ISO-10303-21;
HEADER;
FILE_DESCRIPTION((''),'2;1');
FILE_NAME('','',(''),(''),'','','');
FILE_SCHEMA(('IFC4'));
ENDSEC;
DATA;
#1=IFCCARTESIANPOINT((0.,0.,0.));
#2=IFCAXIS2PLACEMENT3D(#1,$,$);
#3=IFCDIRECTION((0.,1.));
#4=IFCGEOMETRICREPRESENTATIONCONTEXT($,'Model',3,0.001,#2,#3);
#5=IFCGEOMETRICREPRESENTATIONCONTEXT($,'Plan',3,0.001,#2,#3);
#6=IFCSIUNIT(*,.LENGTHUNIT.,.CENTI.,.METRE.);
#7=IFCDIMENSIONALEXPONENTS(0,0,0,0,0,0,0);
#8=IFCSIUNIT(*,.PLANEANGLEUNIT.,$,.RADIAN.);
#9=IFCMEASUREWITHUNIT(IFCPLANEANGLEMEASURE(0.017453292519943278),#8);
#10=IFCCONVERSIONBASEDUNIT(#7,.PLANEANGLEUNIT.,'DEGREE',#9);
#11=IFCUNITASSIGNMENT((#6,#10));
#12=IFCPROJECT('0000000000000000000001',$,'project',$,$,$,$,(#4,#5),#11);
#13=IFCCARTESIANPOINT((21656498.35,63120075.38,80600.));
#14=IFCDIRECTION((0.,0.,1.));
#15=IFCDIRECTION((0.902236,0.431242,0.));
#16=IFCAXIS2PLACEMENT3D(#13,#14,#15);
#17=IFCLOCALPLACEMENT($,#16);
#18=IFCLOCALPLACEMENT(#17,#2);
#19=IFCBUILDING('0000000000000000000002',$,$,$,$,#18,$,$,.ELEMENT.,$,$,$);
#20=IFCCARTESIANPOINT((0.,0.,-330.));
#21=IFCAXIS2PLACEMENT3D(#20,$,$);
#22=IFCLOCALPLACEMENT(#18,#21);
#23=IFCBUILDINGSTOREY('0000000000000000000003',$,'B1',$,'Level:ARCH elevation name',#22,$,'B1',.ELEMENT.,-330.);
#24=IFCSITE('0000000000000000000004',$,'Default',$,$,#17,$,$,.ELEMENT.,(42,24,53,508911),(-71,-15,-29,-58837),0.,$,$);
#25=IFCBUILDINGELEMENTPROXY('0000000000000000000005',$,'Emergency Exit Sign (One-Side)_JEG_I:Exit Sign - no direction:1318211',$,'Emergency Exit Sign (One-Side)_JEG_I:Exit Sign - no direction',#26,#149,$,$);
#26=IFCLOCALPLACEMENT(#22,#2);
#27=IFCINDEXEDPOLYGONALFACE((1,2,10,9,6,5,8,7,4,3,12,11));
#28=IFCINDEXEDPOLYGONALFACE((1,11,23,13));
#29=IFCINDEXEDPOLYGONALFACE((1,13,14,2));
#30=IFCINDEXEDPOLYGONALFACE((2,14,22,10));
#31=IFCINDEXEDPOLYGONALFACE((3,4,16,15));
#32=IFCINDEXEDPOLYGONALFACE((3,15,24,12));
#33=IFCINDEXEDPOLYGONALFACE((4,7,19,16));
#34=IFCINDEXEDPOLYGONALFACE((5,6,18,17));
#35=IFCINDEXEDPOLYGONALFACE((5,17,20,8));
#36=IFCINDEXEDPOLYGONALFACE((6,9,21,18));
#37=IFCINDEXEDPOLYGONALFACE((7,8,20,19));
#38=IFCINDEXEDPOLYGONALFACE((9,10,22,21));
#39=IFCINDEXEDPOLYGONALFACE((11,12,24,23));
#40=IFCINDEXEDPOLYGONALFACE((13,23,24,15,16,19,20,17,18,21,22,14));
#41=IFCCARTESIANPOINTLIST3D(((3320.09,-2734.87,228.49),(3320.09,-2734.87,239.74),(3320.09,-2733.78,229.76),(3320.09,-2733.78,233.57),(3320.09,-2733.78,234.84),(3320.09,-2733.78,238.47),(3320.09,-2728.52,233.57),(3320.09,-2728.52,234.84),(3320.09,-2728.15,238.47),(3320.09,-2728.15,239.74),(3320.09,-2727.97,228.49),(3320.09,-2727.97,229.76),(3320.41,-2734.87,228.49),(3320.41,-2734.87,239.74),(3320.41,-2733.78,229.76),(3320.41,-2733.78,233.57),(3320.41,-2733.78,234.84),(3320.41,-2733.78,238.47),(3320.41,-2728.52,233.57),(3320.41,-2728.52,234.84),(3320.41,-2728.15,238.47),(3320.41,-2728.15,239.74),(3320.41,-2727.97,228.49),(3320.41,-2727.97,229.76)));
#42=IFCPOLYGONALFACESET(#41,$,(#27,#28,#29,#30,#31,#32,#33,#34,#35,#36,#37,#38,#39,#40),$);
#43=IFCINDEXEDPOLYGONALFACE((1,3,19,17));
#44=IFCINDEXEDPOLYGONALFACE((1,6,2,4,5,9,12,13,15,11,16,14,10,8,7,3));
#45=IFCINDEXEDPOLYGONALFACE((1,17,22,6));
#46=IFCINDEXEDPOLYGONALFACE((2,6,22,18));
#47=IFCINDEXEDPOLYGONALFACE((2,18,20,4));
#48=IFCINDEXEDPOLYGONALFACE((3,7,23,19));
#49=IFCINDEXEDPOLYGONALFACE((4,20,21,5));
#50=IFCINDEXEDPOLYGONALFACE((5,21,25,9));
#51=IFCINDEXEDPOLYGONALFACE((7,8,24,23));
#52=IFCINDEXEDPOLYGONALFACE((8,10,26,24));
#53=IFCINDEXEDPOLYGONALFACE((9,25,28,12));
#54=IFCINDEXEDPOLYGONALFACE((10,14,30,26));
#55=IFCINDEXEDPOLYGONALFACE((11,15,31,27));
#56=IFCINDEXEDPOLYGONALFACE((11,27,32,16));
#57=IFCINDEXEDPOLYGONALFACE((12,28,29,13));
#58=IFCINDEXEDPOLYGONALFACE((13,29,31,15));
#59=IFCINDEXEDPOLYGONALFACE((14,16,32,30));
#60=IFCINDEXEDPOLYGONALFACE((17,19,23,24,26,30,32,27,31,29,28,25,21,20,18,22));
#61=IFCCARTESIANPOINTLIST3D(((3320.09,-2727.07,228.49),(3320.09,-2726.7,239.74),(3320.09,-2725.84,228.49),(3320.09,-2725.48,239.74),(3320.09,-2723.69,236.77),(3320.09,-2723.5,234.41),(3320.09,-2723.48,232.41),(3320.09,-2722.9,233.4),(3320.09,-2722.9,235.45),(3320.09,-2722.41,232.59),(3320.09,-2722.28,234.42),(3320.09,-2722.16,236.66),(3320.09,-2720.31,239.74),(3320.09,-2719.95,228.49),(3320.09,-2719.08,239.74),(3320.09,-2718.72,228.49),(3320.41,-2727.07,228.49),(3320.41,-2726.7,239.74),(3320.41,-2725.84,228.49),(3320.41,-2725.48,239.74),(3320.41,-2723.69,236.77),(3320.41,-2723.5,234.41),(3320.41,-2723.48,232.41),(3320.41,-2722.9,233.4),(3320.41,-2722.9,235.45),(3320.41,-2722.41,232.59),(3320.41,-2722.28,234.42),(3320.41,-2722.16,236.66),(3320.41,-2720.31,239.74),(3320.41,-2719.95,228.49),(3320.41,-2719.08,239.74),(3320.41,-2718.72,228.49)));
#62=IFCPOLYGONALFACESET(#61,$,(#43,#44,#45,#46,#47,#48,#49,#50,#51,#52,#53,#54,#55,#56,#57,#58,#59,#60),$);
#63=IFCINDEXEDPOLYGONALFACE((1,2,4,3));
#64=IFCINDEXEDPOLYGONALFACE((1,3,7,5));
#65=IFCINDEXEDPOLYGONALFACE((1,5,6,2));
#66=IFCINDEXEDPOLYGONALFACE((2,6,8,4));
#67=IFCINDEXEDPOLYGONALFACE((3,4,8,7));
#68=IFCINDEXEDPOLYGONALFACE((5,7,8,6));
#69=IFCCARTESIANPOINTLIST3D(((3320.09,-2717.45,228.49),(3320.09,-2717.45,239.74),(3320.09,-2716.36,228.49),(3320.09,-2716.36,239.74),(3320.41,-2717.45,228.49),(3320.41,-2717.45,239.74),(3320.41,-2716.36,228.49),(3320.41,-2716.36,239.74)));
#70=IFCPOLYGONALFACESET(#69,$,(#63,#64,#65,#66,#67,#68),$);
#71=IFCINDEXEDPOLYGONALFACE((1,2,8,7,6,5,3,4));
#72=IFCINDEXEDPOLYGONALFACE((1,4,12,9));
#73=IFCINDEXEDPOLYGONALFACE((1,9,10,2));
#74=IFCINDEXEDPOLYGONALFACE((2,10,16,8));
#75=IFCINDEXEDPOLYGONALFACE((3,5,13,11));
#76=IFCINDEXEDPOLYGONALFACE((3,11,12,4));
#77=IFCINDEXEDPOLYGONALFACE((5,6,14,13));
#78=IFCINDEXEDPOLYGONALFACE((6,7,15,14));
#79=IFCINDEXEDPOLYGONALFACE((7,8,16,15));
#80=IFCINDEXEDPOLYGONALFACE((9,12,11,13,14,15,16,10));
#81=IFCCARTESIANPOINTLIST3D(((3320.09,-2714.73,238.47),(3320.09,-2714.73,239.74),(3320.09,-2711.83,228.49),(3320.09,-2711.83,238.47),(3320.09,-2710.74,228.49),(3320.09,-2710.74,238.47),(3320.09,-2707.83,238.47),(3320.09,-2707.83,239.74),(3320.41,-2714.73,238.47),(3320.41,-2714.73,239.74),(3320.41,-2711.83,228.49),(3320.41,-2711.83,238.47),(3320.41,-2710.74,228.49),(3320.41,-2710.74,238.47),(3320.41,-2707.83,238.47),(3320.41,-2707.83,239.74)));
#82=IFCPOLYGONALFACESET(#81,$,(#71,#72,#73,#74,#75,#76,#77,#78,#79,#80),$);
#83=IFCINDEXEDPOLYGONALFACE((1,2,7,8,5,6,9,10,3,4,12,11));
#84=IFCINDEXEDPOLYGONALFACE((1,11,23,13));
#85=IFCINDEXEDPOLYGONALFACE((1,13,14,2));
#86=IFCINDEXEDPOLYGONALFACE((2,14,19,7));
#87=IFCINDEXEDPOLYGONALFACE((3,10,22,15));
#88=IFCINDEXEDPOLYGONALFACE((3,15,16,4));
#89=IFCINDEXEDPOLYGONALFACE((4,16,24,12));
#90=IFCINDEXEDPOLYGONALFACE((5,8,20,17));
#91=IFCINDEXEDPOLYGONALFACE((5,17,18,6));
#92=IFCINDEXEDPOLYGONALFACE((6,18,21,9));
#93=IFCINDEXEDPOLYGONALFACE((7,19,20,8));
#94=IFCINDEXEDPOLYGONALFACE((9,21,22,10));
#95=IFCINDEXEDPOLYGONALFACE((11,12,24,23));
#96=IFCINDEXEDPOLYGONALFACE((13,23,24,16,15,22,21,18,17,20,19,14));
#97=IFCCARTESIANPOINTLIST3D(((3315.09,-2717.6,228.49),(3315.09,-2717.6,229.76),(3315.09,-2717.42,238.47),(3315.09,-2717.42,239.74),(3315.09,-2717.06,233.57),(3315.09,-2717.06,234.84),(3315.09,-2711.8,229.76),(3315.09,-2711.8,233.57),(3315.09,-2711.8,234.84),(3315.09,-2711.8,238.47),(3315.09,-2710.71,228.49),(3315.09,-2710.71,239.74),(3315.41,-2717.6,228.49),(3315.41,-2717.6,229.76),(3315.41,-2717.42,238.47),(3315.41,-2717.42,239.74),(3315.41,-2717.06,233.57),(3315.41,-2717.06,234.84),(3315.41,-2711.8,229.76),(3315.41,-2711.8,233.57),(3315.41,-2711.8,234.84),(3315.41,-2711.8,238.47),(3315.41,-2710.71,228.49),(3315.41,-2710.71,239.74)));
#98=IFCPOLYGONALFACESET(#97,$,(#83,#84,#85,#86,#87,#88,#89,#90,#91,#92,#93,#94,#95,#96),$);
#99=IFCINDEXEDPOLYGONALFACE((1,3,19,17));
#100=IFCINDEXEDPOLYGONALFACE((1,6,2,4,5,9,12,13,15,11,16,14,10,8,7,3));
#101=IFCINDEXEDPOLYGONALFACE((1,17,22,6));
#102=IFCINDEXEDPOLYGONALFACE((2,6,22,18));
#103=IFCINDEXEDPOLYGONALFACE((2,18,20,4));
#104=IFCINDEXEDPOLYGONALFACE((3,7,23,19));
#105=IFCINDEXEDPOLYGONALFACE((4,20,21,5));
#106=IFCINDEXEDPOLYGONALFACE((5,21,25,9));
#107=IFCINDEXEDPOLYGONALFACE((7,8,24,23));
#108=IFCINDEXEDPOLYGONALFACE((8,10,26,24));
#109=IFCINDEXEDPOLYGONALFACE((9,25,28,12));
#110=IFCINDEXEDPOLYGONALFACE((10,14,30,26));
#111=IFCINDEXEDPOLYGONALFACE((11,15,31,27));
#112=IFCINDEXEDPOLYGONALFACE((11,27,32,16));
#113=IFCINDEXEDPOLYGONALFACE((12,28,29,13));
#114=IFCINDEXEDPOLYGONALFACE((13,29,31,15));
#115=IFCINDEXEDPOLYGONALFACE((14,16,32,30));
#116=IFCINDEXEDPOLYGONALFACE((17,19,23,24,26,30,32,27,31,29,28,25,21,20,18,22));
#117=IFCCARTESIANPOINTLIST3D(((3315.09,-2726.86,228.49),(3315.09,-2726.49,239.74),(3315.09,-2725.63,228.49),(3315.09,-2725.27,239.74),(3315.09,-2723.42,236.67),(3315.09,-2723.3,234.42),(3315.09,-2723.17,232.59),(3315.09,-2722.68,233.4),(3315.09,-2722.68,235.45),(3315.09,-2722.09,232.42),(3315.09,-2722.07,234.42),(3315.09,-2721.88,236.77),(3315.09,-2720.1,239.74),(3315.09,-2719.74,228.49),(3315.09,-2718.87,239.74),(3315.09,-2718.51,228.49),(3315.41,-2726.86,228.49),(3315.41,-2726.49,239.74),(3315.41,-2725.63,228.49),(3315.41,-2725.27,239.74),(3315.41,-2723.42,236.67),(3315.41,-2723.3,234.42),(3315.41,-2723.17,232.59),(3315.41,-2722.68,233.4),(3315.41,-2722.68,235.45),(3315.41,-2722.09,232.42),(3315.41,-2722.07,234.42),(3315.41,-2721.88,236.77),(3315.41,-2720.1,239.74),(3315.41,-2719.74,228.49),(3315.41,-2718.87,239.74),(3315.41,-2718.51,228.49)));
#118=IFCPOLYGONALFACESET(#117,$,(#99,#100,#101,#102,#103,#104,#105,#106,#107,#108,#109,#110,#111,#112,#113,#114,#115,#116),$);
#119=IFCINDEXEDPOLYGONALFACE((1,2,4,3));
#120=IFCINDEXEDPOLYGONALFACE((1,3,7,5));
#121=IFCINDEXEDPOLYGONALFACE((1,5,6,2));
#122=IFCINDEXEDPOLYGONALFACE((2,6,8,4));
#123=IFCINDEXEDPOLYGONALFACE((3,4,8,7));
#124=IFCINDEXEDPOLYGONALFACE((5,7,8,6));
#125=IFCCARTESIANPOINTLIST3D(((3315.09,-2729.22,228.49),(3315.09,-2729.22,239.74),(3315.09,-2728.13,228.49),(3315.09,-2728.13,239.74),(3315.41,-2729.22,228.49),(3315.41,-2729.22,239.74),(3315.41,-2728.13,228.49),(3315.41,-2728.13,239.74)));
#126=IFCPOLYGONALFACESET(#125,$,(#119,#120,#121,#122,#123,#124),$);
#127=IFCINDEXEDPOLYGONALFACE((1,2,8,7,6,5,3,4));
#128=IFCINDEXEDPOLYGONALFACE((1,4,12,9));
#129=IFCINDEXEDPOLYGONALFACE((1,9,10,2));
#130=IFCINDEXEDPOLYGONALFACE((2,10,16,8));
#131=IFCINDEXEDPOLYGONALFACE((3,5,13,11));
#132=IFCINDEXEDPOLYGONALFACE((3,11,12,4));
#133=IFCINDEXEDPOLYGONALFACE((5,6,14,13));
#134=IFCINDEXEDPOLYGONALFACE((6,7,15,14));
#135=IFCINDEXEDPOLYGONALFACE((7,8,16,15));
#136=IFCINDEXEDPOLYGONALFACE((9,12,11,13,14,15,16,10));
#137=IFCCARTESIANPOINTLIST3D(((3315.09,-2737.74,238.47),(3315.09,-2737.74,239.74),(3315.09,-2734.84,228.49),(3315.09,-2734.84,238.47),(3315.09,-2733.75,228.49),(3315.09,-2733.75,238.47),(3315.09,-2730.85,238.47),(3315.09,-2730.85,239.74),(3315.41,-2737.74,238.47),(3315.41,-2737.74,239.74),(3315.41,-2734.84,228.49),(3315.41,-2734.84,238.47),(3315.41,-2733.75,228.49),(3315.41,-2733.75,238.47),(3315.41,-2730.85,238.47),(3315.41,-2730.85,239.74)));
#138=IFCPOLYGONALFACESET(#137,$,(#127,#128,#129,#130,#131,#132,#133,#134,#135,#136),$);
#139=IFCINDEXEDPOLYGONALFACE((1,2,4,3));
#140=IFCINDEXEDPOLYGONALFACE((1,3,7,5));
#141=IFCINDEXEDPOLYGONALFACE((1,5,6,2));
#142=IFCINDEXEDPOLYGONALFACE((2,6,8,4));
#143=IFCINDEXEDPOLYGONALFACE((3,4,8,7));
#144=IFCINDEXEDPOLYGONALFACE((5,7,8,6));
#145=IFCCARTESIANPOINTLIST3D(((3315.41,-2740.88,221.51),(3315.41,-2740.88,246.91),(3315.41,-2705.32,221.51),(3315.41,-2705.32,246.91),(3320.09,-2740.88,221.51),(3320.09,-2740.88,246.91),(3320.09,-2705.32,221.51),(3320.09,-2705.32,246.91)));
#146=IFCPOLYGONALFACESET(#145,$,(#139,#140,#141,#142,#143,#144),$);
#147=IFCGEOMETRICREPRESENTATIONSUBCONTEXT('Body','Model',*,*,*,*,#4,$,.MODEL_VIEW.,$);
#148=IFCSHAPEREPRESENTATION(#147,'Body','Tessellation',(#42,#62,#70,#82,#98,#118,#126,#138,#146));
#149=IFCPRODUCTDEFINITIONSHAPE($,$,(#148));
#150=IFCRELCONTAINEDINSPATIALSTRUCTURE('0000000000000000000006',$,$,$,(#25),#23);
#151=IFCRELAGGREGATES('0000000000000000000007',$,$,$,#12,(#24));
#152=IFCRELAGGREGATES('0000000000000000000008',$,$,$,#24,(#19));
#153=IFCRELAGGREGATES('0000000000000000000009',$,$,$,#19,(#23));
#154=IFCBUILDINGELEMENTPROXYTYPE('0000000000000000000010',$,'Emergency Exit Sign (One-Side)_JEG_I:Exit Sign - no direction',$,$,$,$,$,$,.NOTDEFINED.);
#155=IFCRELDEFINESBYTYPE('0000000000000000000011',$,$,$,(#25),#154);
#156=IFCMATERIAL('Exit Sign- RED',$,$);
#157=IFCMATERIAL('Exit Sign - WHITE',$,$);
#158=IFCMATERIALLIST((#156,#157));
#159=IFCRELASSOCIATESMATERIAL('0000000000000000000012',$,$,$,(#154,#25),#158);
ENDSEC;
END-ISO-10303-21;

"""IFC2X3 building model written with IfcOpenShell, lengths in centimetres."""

from ifc_helpers import new_model, entity, si_unit, converted_unit, direction, frame, frame_2d, origin, origin_2d_with_axis, place, context, subcontext, project, spatial, polyline, rectangle, outline, extrude, source, transform, mapped, material, material_list, type_object, type_shapes, element, save


model = new_model("IFC2X3")

# Units and contexts
model_context = context("Model", 3, precision=0.001, world=origin(), true_north=direction((0.0, 1.0)))
plan_context = context("Plan", 3, precision=0.001, world=origin(), true_north=direction((0.0, 1.0)))
body_context = subcontext(model_context, "Body", "Model", "MODEL_VIEW")
ifc_project = project(units=[si_unit("LENGTHUNIT", "METRE", prefix="CENTI"), converted_unit("PLANEANGLEUNIT", "DEGREE", entity("IfcPlaneAngleMeasure", 0.017453292519943278), si_unit("PLANEANGLEUNIT", "RADIAN"), dimensions=[0, 0, 0, 0, 0, 0, 0])], contexts=[model_context, plan_context])

# Site, building, storey
site_placement = place(None, frame((21656498.35, 63120075.38, 80600.0), z_axis=(0.0, 0.0, 1.0), x_axis=(0.902236, 0.431242, 0.0)))
site = spatial("IfcSite", under=ifc_project, at=site_placement, Name="Default", CompositionType="ELEMENT", RefLatitude=(42, 24, 53, 508911), RefLongitude=(-71, -15, -29, -58837), RefElevation=0.0)
building_placement = place(site_placement, origin())
building = spatial("IfcBuilding", under=site, at=building_placement, CompositionType="ELEMENT")
storey_placement = place(building_placement, frame((0.0, 0.0, -330.0)))
storey = spatial("IfcBuildingStorey", under=building, at=storey_placement, Name="B1", ObjectType="Level:ARCH elevation name", LongName="B1", CompositionType="ELEMENT", Elevation=-330.0)

# Shared definitions
ifc_material_1 = material(Name="Exit Sign - WHITE")
ifc_material_2 = material(Name="Exit Sign- RED")

# Building element proxy
ifc_material_list_1 = material_list([ifc_material_2, ifc_material_1])
building_element_proxy_type_1 = type_object("IfcBuildingElementProxyType", Name="Emergency Exit Sign (One-Side)_JEG_I:Exit Sign - no direction", PredefinedType="NOTDEFINED", material=ifc_material_list_1)
shared_shape_1 = source(origin(), body_context, "Body", "SweptSolid", [
    extrude(outline(polyline([(-5.65, -3.69), (5.59, -3.69), (5.59, 3.02), (4.32, 3.02), (4.32, -2.6), (0.7, -2.6), (0.7, 2.66), (-0.57, 2.66), (-0.57, -2.6), (-4.38, -2.6), (-4.38, 3.21), (-5.65, 3.21), (-5.65, -3.69)])), frame((-8.08, -5.22, 12.64), z_axis=(0.0, 1.0, 0.0), x_axis=(0.0, 0.0, 1.0)), (0.0, 0.0, 1.0), 0.32),
    extrude(outline(polyline([(-7.14, 0.57), (-6.5, -0.49), (-1.93, -0.48), (-0.78, -0.48), (-1.23, -1.32), (-3.47, -5.53), (-2.84, -6.59), (0.41, -0.48), (6.62, -0.48), (5.99, 0.57), (2.4, 0.57), (0.98, 0.58), (1.7, 1.94), (3.32, 5.0), (2.69, 6.05), (-0.22, 0.57), (-7.14, 0.57)])), frame((0.2, -5.22, 12.81), z_axis=(0.0, -1.0, 0.0), x_axis=(0.515099, 0.0, 0.857131)), (0.0, 0.0, -1.0), 0.32),
    extrude(rectangle(XDim=0.32, YDim=1.09, at=frame_2d((0.0, 0.0), x_axis=(1.0, 0.0))), frame((6.19, -5.06, 6.99), z_axis=(0.0, 0.0, 1.0), x_axis=(0.0, 1.0, 0.0)), (0.0, 0.0, 1.0), 11.25),
    extrude(outline(polyline([(-7.8, 0.54), (-7.8, -0.54), (2.18, -0.54), (2.18, -3.45), (3.45, -3.45), (3.45, 3.45), (2.18, 3.45), (2.18, 0.54), (-7.8, 0.54)])), frame((11.82, -5.22, 14.79), z_axis=(0.0, -1.0, 0.0), x_axis=(0.0, 0.0, 1.0)), (0.0, 0.0, -1.0), 0.32),
    extrude(outline(polyline([(-3.69, -5.65), (3.21, -5.65), (3.21, -4.38), (-2.6, -4.38), (-2.6, -0.57), (2.66, -0.57), (2.66, 0.7), (-2.6, 0.7), (-2.6, 4.32), (3.02, 4.32), (3.02, 5.59), (-3.69, 5.59), (-3.69, -5.65)])), frame((8.7, -0.22, 12.65), z_axis=(0.0, 1.0, 0.0), x_axis=(-1.0, 0.0, 0.0)), (0.0, 0.0, 1.0), 0.32),
    extrude(outline(polyline([(-4.16, -5.82), (-2.93, -5.82), (-0.58, -1.9), (0.01, -0.92), (0.5, -1.73), (2.96, -5.82), (4.18, -5.82), (0.62, 0.1), (3.82, 5.42), (2.59, 5.42), (0.75, 2.35), (0.01, 1.14), (-0.79, 2.46), (-2.57, 5.42), (-3.8, 5.42), (-0.6, 0.1), (-4.16, -5.82)])), frame((0.43, -0.22, 12.82), z_axis=(0.0, 1.0, 0.0), x_axis=(-1.0, 0.0, 0.0)), (0.0, 0.0, 1.0), 0.32),
    extrude(rectangle(XDim=0.32, YDim=1.09, at=origin_2d_with_axis()), frame((-5.57, -0.06, 6.99), z_axis=(0.0, 0.0, 1.0), x_axis=(0.0, -1.0, 0.0)), (0.0, 0.0, 1.0), 11.25),
    extrude(outline(polyline([(-0.54, -7.8), (0.54, -7.8), (0.54, 2.18), (3.45, 2.18), (3.45, 3.45), (-3.45, 3.45), (-3.45, 2.18), (-0.54, 2.18), (-0.54, -7.8)])), frame((-11.2, -0.22, 14.79), z_axis=(0.0, 1.0, 0.0), x_axis=(-1.0, 0.0, 0.0)), (0.0, 0.0, 1.0), 0.32),
    extrude(rectangle(XDim=4.68, YDim=35.56, at=origin_2d_with_axis()), frame((0.0, -2.56, 0.01), z_axis=(0.0, 0.0, 1.0), x_axis=(0.0, 1.0, 0.0)), (0.0, 0.0, 1.0), 25.4),
])
type_shapes(building_element_proxy_type_1, [shared_shape_1])
for number, where, z_axis, x_axis, name in (
    (1, (3315.19, -2723.1, 221.5), (0.0, 0.0, 1.0), (0.0, 1.0, 0.0), "Emergency Exit Sign (One-Side)_JEG_I:Exit Sign - no direction:1318211"),
):
    element("IfcBuildingElementProxy", number, at=place(storey_placement, frame(where, z_axis=z_axis, x_axis=x_axis)), inside=storey, type_object=building_element_proxy_type_1, material=ifc_material_list_1, Name=name, ObjectType="Emergency Exit Sign (One-Side)_JEG_I:Exit Sign - no direction", context=body_context, shape_type="MappedRepresentation", body=[
        mapped(shared_shape_1, transform((0.0, 0.0, 0.0), scale=1.0)),
    ])

save(model, "model.ifc")
